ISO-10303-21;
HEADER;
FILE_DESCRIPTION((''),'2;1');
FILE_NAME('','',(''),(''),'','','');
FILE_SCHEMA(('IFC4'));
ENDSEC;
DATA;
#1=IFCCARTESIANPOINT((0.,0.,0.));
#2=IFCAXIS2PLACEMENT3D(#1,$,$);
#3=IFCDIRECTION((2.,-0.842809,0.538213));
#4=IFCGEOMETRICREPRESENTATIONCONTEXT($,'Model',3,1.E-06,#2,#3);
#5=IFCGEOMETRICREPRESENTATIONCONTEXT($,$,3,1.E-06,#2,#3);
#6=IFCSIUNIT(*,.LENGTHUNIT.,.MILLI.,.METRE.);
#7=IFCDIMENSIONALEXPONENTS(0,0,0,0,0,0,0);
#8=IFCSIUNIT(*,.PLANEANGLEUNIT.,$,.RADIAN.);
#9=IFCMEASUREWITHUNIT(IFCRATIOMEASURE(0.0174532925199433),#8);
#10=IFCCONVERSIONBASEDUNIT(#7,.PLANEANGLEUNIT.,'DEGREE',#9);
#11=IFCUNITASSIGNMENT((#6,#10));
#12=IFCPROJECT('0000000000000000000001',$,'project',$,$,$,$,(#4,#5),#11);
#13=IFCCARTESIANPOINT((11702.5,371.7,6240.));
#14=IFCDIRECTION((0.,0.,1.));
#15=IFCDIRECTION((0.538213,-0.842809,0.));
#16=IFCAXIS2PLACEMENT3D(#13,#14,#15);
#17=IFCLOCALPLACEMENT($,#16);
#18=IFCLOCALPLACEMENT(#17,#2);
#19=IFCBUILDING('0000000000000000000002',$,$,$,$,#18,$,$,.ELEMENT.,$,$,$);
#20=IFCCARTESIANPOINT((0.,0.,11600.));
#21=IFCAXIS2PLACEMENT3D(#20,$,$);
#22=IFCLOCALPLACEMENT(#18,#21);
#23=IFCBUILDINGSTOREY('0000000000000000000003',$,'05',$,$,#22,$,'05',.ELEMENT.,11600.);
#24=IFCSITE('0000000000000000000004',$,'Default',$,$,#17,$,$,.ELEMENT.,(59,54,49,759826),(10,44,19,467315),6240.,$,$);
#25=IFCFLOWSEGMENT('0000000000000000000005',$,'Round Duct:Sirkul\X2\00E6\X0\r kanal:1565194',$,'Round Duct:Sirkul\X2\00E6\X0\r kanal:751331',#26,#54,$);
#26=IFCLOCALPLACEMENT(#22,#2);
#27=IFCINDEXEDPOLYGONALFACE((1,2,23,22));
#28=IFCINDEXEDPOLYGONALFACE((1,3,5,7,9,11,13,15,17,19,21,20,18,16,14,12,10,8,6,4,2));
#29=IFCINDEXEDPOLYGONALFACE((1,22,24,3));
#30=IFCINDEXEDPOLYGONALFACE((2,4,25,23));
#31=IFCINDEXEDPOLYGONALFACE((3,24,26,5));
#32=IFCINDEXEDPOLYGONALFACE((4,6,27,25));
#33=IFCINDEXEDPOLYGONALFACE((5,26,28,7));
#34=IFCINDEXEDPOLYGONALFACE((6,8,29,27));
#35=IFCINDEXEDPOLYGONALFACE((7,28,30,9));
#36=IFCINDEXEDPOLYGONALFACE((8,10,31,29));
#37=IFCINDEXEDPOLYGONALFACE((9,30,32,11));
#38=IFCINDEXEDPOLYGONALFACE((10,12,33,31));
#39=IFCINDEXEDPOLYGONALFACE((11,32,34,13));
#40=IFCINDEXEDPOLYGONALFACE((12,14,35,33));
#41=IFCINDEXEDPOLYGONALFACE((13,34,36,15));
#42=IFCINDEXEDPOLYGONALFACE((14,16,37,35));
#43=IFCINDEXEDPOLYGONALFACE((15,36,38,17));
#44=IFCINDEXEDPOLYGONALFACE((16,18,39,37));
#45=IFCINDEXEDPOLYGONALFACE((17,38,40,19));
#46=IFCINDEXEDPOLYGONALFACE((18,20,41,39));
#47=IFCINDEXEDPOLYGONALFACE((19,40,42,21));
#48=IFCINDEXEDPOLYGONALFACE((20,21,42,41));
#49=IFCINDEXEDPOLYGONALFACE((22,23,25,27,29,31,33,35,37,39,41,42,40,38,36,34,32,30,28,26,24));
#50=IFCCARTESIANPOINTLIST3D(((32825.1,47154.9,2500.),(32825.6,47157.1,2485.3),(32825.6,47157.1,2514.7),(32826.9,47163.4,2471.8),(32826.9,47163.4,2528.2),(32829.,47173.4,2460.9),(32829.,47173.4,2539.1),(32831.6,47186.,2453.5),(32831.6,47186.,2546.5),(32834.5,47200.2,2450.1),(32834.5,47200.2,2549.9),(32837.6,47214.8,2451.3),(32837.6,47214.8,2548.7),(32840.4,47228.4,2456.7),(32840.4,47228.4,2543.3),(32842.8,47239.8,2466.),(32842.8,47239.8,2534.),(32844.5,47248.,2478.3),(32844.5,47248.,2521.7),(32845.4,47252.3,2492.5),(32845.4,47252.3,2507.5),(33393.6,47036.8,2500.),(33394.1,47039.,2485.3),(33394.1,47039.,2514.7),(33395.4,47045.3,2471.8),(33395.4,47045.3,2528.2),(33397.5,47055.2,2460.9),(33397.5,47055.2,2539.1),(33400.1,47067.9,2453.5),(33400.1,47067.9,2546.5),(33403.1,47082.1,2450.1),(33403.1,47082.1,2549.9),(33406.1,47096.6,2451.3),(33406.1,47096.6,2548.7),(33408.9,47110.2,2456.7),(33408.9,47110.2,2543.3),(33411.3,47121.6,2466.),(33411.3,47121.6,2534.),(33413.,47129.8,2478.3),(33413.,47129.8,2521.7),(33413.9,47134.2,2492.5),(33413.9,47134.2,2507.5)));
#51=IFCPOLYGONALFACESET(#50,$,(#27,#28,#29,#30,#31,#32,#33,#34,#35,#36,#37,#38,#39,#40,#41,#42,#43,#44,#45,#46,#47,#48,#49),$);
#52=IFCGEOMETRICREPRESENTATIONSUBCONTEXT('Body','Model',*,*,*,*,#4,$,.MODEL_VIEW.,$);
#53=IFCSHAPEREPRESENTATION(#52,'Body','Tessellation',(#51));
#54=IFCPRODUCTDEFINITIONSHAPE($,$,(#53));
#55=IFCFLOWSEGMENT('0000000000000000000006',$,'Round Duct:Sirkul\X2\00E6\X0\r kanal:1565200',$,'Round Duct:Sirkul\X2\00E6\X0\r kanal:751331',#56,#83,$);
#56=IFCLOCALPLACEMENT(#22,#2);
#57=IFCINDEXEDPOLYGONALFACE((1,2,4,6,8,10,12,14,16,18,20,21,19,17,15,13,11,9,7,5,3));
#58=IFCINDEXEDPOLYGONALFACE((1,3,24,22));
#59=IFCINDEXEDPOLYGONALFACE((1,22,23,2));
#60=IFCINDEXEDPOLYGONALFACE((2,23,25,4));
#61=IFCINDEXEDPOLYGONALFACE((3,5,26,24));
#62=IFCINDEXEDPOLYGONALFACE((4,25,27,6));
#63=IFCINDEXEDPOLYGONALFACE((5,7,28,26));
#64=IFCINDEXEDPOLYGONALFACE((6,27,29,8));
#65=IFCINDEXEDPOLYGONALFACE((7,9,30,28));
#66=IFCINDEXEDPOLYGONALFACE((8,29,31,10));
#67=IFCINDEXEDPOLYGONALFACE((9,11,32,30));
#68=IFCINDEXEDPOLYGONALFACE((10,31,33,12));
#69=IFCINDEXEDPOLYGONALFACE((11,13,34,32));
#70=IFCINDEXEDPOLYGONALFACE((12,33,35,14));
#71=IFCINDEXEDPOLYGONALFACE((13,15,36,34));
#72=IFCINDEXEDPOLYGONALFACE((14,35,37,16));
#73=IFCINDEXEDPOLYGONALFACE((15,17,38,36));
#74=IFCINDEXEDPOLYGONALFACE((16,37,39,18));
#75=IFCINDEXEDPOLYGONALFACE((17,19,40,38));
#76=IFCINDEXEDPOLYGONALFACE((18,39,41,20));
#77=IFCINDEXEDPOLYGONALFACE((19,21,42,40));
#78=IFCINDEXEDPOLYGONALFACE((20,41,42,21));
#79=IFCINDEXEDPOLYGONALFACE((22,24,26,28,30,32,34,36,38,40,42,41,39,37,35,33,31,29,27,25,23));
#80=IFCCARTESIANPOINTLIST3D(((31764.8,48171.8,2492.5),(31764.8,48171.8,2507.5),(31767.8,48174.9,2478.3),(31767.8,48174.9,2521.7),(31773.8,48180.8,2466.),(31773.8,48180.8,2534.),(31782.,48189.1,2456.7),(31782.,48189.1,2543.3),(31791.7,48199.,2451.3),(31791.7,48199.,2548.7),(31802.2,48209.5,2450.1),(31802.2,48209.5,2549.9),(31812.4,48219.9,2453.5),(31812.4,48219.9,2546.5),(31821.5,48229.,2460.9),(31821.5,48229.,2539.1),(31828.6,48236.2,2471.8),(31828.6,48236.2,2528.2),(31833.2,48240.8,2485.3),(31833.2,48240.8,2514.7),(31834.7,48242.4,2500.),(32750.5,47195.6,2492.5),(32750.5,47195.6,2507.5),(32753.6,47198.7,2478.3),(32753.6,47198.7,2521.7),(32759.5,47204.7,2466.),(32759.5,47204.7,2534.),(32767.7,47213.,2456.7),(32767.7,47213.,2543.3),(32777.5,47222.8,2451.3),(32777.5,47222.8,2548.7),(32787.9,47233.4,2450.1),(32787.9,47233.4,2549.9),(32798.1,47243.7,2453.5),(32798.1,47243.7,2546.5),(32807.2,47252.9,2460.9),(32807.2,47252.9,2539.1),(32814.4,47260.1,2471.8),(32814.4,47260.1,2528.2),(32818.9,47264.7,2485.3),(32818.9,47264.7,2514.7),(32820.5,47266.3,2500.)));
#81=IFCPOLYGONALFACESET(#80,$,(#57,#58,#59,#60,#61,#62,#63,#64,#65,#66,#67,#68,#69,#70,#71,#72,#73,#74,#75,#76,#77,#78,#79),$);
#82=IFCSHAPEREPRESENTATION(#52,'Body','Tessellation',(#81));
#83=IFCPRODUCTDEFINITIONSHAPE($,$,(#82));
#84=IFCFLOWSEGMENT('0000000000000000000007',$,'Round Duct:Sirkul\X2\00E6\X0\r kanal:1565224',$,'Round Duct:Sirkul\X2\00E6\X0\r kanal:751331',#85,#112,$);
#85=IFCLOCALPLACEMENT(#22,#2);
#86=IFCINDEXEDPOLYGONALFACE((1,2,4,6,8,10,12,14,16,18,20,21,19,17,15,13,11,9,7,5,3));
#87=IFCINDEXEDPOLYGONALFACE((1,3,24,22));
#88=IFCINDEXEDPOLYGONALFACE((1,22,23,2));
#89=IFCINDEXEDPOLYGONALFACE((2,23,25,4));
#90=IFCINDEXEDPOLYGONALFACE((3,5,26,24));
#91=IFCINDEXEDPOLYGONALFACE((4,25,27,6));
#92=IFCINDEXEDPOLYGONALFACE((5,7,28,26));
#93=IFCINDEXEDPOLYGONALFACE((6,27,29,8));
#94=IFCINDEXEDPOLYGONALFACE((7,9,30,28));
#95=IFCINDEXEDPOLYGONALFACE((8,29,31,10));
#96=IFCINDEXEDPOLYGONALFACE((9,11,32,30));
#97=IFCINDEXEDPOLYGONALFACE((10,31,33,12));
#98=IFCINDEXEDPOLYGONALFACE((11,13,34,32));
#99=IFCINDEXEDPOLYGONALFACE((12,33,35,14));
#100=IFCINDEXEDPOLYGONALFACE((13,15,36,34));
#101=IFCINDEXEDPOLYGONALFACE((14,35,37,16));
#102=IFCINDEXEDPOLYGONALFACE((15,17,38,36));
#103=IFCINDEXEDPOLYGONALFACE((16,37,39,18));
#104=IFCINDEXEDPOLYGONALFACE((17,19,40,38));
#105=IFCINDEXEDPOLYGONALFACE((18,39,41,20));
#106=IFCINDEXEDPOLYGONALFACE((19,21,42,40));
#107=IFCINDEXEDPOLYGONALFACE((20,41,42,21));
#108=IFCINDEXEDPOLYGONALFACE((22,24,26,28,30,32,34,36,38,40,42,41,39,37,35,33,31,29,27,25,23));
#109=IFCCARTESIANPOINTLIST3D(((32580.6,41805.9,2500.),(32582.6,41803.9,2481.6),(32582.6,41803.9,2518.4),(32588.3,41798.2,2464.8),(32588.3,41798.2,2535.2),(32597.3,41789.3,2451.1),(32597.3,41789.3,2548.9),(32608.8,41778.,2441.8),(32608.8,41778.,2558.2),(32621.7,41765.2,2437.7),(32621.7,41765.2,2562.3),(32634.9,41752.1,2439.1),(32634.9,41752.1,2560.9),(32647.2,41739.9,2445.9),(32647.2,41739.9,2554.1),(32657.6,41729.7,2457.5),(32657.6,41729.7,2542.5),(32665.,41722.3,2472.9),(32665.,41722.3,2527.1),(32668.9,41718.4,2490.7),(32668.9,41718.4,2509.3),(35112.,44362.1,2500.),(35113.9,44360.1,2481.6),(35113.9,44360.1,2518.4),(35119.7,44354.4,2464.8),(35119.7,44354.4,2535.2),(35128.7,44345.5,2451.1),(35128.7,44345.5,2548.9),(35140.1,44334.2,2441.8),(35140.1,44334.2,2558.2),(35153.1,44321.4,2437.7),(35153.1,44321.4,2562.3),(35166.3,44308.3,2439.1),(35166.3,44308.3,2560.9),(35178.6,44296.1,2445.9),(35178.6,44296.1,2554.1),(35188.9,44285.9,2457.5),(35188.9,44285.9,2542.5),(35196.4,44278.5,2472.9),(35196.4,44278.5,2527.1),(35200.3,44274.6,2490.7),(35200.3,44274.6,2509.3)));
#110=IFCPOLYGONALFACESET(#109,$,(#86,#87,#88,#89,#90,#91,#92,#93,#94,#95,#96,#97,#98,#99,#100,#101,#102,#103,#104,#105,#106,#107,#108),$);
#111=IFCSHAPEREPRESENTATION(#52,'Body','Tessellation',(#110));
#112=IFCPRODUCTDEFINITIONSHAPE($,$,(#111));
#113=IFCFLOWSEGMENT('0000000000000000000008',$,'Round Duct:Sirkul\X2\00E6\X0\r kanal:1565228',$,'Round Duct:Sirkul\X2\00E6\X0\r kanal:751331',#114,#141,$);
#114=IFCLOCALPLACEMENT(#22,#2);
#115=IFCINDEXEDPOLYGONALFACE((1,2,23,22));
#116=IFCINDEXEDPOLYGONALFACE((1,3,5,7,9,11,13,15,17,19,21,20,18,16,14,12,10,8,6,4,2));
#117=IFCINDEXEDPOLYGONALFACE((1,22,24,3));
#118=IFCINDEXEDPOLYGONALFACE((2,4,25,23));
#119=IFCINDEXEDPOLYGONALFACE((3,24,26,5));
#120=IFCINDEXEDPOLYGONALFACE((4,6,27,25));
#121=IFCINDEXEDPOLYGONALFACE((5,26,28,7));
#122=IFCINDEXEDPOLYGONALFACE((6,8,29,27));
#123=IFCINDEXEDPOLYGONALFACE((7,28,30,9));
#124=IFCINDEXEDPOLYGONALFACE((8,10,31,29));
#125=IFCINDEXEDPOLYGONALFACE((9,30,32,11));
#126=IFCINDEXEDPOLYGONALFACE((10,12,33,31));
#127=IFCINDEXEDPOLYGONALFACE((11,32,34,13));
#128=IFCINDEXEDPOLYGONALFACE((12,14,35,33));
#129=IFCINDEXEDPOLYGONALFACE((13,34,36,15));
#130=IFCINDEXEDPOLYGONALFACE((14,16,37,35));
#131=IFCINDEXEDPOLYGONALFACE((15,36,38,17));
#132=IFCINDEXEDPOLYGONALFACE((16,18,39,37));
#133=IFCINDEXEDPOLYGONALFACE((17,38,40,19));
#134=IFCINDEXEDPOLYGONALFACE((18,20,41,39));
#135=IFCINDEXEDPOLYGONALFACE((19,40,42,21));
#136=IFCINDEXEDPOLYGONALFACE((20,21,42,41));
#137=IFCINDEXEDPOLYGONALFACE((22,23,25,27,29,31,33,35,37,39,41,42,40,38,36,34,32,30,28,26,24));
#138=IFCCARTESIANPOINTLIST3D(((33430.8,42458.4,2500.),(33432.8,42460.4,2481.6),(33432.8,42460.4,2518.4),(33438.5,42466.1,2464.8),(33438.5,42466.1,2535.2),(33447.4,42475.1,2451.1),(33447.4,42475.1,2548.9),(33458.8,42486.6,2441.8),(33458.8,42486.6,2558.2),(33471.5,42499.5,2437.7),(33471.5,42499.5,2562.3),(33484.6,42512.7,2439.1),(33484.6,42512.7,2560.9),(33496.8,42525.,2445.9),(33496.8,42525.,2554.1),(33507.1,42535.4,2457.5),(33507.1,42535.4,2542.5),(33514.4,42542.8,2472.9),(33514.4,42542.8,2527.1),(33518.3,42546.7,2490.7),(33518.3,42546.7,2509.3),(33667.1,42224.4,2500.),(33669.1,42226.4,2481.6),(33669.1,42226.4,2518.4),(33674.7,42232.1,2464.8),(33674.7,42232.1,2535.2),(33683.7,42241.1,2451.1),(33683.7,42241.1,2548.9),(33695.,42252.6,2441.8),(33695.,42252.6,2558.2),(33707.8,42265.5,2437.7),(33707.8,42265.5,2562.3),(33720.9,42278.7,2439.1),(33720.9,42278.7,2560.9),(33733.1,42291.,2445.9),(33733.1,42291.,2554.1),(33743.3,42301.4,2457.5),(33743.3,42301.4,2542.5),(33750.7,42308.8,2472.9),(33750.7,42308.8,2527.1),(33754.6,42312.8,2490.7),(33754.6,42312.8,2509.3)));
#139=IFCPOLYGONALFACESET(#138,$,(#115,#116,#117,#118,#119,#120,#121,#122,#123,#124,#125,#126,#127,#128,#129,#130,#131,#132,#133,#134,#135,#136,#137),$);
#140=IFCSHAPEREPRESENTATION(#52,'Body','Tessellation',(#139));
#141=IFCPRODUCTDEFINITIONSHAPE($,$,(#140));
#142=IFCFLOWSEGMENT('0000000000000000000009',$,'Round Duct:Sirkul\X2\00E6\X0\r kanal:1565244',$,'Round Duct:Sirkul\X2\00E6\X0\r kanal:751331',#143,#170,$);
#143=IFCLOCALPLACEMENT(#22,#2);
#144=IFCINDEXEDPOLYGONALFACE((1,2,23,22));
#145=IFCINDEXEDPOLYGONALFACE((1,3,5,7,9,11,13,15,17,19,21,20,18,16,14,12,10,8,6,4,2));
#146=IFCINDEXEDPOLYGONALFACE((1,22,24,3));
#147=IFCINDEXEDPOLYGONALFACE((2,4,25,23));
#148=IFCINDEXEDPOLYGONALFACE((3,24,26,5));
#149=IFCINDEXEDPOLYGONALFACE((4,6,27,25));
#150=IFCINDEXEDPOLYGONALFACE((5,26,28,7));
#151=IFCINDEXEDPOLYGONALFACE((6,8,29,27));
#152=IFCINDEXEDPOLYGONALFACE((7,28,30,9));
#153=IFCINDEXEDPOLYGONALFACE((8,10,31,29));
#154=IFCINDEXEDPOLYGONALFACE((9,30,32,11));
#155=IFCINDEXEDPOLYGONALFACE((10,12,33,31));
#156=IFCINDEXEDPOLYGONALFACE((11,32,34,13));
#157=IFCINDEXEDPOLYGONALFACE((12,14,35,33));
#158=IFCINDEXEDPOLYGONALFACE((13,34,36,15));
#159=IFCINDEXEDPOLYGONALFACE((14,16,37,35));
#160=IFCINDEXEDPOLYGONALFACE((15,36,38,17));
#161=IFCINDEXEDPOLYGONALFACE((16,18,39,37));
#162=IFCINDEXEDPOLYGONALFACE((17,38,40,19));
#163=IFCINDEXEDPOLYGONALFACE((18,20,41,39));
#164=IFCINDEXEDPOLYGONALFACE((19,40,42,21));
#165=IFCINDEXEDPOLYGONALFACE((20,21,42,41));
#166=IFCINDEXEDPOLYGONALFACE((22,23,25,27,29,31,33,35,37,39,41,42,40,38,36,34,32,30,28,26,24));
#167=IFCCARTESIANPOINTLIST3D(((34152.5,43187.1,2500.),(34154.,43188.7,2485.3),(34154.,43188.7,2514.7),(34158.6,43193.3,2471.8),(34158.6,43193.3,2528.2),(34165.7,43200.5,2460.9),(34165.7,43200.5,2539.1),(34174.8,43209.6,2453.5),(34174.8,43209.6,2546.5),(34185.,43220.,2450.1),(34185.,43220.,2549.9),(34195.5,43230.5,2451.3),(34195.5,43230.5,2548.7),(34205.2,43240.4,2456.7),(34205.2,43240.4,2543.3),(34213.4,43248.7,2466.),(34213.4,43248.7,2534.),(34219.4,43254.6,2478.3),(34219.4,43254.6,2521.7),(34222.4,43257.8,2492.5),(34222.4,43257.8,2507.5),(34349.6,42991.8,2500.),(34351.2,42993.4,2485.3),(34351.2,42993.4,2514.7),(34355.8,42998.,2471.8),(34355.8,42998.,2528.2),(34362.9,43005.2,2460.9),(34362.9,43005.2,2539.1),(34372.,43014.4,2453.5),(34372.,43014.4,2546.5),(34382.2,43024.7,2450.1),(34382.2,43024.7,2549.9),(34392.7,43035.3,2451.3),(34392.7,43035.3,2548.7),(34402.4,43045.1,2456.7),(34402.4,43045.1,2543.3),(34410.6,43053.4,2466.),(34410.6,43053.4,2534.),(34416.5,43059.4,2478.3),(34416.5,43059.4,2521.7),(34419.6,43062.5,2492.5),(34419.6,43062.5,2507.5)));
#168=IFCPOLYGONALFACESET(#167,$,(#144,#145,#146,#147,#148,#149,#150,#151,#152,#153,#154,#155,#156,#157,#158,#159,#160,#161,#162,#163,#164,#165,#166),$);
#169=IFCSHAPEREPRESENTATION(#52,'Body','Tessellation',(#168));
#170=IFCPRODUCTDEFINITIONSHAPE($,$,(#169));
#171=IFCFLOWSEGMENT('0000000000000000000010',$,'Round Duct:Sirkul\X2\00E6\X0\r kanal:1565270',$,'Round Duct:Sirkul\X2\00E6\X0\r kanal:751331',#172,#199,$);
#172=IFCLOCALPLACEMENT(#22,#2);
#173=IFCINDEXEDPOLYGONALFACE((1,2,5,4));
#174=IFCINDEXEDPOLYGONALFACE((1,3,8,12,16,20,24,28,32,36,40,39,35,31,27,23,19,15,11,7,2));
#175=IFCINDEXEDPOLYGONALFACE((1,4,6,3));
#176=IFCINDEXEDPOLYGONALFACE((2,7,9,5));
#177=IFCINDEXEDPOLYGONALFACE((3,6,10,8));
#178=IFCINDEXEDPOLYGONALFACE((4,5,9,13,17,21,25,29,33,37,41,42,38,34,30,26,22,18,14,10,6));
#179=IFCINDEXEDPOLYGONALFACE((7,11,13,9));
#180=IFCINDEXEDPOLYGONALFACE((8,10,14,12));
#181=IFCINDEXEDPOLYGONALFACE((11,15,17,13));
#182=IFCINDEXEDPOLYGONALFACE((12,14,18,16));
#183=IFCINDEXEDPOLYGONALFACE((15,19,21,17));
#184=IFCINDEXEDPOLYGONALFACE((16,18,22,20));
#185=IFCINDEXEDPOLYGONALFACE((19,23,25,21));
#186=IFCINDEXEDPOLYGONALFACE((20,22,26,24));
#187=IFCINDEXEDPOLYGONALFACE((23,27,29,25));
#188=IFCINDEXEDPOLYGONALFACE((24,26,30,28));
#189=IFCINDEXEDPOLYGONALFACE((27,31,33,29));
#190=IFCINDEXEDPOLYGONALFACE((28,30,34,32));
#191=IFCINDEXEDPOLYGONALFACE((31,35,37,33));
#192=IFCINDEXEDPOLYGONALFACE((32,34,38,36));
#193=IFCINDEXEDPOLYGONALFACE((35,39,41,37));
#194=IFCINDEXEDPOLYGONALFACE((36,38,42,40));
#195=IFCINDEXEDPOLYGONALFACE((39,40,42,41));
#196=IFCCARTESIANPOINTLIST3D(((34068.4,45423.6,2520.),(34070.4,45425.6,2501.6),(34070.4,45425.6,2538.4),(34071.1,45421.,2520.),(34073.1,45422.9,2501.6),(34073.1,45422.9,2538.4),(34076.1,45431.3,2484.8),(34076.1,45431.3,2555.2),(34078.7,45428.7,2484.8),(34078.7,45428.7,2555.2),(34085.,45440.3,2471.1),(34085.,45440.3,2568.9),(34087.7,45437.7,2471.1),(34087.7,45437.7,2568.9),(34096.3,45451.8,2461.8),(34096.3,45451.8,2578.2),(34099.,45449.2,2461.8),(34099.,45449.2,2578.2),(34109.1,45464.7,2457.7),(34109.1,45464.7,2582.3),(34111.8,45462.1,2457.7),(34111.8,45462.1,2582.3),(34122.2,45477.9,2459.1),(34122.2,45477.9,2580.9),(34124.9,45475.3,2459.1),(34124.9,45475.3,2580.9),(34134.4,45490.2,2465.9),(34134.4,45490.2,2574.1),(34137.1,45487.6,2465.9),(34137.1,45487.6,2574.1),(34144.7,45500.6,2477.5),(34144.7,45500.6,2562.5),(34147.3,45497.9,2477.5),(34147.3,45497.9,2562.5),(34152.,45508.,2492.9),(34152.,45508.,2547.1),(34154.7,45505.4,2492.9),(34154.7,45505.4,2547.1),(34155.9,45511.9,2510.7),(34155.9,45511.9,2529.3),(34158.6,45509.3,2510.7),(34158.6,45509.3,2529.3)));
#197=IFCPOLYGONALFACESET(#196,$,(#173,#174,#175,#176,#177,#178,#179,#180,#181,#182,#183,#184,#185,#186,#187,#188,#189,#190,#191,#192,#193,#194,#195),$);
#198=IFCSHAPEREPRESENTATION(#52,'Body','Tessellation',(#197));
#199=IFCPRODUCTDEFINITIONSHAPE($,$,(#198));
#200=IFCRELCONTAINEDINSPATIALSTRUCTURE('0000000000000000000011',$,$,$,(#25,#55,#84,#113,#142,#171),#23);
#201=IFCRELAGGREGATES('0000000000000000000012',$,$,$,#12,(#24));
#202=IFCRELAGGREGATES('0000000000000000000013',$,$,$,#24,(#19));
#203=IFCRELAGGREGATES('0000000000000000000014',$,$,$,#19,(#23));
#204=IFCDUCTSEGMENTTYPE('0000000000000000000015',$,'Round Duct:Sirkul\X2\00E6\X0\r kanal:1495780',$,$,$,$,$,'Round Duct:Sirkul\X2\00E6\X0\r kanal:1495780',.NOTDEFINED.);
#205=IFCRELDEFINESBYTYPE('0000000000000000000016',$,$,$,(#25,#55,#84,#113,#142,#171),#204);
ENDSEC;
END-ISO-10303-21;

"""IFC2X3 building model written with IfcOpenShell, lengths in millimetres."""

from ifc_helpers import new_model, entity, si_unit, converted_unit, direction, frame, frame_2d, origin, origin_2d_with_axis, place, context, subcontext, project, spatial, circle, extrude, type_object, element, save


model = new_model("IFC2X3")

# Units and contexts
model_context = context("Model", 3, precision=1e-06, world=origin(), true_north=direction((2.0, -0.842809, 0.538213)))
context_of_model = context(None, 3, precision=1e-06, world=origin(), true_north=direction((2.0, -0.842809, 0.538213)))
body_context = subcontext(model_context, "Body", "Model", "MODEL_VIEW")
ifc_project = project(units=[si_unit("LENGTHUNIT", "METRE", prefix="MILLI"), converted_unit("PLANEANGLEUNIT", "DEGREE", entity("IfcRatioMeasure", 0.0174532925199433), si_unit("PLANEANGLEUNIT", "RADIAN"), dimensions=[0, 0, 0, 0, 0, 0, 0])], contexts=[model_context, context_of_model])

# Site, building, storey
site_placement = place(None, frame((11702.5, 371.7, 6240.0), z_axis=(0.0, 0.0, 1.0), x_axis=(0.538213, -0.842809, 0.0)))
site = spatial("IfcSite", under=ifc_project, at=site_placement, Name="Default", CompositionType="ELEMENT", RefLatitude=(59, 54, 49, 759826), RefLongitude=(10, 44, 19, 467315), RefElevation=6240.0)
building_placement = place(site_placement, origin())
building = spatial("IfcBuilding", under=site, at=building_placement, CompositionType="ELEMENT")
storey_placement = place(building_placement, frame((0.0, 0.0, 11600.0)))
storey = spatial("IfcBuildingStorey", under=building, at=storey_placement, Name="05", LongName="05", CompositionType="ELEMENT", Elevation=11600.0)

# Flow segments
duct_segment_type = type_object("IfcDuctSegmentType", Name="Round Duct:Sirkulær kanal:1495780", ElementType="Round Duct:Sirkulær kanal:1495780", PredefinedType="NOTDEFINED")
flow_segment_1_placement = place(storey_placement, origin())
element("IfcFlowSegment", 1, at=flow_segment_1_placement, inside=storey, type_object=duct_segment_type, Name="Round Duct:Sirkulær kanal:1565194", ObjectType="Round Duct:Sirkulær kanal:751331", context=body_context, shape_type="SweptSolid", body=[
    extrude(circle(Radius=50.0, at=origin_2d_with_axis()), frame((33403.8, 47085.7, 2500.0), z_axis=(-0.979081, 0.203471, 0.0), x_axis=(-0.203471, -0.979081, 0.0)), (0.0, 0.0, 1.0), 580.7),
])
flow_segment_2_placement = place(storey_placement, origin())
element("IfcFlowSegment", 2, at=flow_segment_2_placement, inside=storey, type_object=duct_segment_type, Name="Round Duct:Sirkulær kanal:1565200", ObjectType="Round Duct:Sirkulær kanal:751331", context=body_context, shape_type="SweptSolid", body=[
    extrude(circle(Radius=50.0, at=origin_2d_with_axis()), frame((31799.5, 48206.9, 2500.0), z_axis=(0.710554, -0.703643, 0.0), x_axis=(0.703643, 0.710554, 0.0)), (0.0, 0.0, 1.0), 1387.3),
])
flow_segment_3_placement = place(storey_placement, origin())
element("IfcFlowSegment", 3, at=flow_segment_3_placement, inside=storey, type_object=duct_segment_type, Name="Round Duct:Sirkulær kanal:1565224", ObjectType="Round Duct:Sirkulær kanal:751331", context=body_context, shape_type="SweptSolid", body=[
    extrude(circle(Radius=62.5, at=origin_2d_with_axis()), frame((32625.0, 41761.9, 2500.0), z_axis=(0.703643, 0.710554, 0.0), x_axis=(-0.710554, 0.703643, 0.0)), (0.0, 0.0, 1.0), 3597.5),
])
flow_segment_4_placement = place(storey_placement, origin())
element("IfcFlowSegment", 4, at=flow_segment_4_placement, inside=storey, type_object=duct_segment_type, Name="Round Duct:Sirkulær kanal:1565228", ObjectType="Round Duct:Sirkulær kanal:751331", context=body_context, shape_type="SweptSolid", body=[
    extrude(circle(Radius=62.5, at=frame_2d((0.0, 0.0), x_axis=(1.0, 0.0))), frame((33711.1, 42268.8, 2500.0), z_axis=(-0.710554, 0.703643, 0.0), x_axis=(-0.703643, -0.710554, 0.0)), (0.0, 0.0, 1.0), 332.5),
])
flow_segment_5_placement = place(storey_placement, origin())
element("IfcFlowSegment", 5, at=flow_segment_5_placement, inside=storey, type_object=duct_segment_type, Name="Round Duct:Sirkulær kanal:1565244", ObjectType="Round Duct:Sirkulær kanal:751331", context=body_context, shape_type="SweptSolid", body=[
    extrude(circle(Radius=50.0, at=origin_2d_with_axis()), frame((34187.7, 43222.6, 2500.0), z_axis=(0.710554, -0.703643, 0.0), x_axis=(-0.703643, -0.710554, 0.0)), (0.0, 0.0, 1.0), 277.5),
])
flow_segment_6_placement = place(storey_placement, origin())
element("IfcFlowSegment", 6, at=flow_segment_6_placement, inside=storey, type_object=duct_segment_type, Name="Round Duct:Sirkulær kanal:1565270", ObjectType="Round Duct:Sirkulær kanal:751331", context=body_context, shape_type="SweptSolid", body=[
    extrude(circle(Radius=62.5, at=frame_2d((0.0, 0.0), x_axis=(1.0, 0.0))), frame((34112.4, 45468.0, 2520.0), z_axis=(0.710554, -0.703643, 0.0), x_axis=(-0.703643, -0.710554, 0.0)), (0.0, 0.0, 1.0), 3.7),
])

save(model, "model.ifc")
